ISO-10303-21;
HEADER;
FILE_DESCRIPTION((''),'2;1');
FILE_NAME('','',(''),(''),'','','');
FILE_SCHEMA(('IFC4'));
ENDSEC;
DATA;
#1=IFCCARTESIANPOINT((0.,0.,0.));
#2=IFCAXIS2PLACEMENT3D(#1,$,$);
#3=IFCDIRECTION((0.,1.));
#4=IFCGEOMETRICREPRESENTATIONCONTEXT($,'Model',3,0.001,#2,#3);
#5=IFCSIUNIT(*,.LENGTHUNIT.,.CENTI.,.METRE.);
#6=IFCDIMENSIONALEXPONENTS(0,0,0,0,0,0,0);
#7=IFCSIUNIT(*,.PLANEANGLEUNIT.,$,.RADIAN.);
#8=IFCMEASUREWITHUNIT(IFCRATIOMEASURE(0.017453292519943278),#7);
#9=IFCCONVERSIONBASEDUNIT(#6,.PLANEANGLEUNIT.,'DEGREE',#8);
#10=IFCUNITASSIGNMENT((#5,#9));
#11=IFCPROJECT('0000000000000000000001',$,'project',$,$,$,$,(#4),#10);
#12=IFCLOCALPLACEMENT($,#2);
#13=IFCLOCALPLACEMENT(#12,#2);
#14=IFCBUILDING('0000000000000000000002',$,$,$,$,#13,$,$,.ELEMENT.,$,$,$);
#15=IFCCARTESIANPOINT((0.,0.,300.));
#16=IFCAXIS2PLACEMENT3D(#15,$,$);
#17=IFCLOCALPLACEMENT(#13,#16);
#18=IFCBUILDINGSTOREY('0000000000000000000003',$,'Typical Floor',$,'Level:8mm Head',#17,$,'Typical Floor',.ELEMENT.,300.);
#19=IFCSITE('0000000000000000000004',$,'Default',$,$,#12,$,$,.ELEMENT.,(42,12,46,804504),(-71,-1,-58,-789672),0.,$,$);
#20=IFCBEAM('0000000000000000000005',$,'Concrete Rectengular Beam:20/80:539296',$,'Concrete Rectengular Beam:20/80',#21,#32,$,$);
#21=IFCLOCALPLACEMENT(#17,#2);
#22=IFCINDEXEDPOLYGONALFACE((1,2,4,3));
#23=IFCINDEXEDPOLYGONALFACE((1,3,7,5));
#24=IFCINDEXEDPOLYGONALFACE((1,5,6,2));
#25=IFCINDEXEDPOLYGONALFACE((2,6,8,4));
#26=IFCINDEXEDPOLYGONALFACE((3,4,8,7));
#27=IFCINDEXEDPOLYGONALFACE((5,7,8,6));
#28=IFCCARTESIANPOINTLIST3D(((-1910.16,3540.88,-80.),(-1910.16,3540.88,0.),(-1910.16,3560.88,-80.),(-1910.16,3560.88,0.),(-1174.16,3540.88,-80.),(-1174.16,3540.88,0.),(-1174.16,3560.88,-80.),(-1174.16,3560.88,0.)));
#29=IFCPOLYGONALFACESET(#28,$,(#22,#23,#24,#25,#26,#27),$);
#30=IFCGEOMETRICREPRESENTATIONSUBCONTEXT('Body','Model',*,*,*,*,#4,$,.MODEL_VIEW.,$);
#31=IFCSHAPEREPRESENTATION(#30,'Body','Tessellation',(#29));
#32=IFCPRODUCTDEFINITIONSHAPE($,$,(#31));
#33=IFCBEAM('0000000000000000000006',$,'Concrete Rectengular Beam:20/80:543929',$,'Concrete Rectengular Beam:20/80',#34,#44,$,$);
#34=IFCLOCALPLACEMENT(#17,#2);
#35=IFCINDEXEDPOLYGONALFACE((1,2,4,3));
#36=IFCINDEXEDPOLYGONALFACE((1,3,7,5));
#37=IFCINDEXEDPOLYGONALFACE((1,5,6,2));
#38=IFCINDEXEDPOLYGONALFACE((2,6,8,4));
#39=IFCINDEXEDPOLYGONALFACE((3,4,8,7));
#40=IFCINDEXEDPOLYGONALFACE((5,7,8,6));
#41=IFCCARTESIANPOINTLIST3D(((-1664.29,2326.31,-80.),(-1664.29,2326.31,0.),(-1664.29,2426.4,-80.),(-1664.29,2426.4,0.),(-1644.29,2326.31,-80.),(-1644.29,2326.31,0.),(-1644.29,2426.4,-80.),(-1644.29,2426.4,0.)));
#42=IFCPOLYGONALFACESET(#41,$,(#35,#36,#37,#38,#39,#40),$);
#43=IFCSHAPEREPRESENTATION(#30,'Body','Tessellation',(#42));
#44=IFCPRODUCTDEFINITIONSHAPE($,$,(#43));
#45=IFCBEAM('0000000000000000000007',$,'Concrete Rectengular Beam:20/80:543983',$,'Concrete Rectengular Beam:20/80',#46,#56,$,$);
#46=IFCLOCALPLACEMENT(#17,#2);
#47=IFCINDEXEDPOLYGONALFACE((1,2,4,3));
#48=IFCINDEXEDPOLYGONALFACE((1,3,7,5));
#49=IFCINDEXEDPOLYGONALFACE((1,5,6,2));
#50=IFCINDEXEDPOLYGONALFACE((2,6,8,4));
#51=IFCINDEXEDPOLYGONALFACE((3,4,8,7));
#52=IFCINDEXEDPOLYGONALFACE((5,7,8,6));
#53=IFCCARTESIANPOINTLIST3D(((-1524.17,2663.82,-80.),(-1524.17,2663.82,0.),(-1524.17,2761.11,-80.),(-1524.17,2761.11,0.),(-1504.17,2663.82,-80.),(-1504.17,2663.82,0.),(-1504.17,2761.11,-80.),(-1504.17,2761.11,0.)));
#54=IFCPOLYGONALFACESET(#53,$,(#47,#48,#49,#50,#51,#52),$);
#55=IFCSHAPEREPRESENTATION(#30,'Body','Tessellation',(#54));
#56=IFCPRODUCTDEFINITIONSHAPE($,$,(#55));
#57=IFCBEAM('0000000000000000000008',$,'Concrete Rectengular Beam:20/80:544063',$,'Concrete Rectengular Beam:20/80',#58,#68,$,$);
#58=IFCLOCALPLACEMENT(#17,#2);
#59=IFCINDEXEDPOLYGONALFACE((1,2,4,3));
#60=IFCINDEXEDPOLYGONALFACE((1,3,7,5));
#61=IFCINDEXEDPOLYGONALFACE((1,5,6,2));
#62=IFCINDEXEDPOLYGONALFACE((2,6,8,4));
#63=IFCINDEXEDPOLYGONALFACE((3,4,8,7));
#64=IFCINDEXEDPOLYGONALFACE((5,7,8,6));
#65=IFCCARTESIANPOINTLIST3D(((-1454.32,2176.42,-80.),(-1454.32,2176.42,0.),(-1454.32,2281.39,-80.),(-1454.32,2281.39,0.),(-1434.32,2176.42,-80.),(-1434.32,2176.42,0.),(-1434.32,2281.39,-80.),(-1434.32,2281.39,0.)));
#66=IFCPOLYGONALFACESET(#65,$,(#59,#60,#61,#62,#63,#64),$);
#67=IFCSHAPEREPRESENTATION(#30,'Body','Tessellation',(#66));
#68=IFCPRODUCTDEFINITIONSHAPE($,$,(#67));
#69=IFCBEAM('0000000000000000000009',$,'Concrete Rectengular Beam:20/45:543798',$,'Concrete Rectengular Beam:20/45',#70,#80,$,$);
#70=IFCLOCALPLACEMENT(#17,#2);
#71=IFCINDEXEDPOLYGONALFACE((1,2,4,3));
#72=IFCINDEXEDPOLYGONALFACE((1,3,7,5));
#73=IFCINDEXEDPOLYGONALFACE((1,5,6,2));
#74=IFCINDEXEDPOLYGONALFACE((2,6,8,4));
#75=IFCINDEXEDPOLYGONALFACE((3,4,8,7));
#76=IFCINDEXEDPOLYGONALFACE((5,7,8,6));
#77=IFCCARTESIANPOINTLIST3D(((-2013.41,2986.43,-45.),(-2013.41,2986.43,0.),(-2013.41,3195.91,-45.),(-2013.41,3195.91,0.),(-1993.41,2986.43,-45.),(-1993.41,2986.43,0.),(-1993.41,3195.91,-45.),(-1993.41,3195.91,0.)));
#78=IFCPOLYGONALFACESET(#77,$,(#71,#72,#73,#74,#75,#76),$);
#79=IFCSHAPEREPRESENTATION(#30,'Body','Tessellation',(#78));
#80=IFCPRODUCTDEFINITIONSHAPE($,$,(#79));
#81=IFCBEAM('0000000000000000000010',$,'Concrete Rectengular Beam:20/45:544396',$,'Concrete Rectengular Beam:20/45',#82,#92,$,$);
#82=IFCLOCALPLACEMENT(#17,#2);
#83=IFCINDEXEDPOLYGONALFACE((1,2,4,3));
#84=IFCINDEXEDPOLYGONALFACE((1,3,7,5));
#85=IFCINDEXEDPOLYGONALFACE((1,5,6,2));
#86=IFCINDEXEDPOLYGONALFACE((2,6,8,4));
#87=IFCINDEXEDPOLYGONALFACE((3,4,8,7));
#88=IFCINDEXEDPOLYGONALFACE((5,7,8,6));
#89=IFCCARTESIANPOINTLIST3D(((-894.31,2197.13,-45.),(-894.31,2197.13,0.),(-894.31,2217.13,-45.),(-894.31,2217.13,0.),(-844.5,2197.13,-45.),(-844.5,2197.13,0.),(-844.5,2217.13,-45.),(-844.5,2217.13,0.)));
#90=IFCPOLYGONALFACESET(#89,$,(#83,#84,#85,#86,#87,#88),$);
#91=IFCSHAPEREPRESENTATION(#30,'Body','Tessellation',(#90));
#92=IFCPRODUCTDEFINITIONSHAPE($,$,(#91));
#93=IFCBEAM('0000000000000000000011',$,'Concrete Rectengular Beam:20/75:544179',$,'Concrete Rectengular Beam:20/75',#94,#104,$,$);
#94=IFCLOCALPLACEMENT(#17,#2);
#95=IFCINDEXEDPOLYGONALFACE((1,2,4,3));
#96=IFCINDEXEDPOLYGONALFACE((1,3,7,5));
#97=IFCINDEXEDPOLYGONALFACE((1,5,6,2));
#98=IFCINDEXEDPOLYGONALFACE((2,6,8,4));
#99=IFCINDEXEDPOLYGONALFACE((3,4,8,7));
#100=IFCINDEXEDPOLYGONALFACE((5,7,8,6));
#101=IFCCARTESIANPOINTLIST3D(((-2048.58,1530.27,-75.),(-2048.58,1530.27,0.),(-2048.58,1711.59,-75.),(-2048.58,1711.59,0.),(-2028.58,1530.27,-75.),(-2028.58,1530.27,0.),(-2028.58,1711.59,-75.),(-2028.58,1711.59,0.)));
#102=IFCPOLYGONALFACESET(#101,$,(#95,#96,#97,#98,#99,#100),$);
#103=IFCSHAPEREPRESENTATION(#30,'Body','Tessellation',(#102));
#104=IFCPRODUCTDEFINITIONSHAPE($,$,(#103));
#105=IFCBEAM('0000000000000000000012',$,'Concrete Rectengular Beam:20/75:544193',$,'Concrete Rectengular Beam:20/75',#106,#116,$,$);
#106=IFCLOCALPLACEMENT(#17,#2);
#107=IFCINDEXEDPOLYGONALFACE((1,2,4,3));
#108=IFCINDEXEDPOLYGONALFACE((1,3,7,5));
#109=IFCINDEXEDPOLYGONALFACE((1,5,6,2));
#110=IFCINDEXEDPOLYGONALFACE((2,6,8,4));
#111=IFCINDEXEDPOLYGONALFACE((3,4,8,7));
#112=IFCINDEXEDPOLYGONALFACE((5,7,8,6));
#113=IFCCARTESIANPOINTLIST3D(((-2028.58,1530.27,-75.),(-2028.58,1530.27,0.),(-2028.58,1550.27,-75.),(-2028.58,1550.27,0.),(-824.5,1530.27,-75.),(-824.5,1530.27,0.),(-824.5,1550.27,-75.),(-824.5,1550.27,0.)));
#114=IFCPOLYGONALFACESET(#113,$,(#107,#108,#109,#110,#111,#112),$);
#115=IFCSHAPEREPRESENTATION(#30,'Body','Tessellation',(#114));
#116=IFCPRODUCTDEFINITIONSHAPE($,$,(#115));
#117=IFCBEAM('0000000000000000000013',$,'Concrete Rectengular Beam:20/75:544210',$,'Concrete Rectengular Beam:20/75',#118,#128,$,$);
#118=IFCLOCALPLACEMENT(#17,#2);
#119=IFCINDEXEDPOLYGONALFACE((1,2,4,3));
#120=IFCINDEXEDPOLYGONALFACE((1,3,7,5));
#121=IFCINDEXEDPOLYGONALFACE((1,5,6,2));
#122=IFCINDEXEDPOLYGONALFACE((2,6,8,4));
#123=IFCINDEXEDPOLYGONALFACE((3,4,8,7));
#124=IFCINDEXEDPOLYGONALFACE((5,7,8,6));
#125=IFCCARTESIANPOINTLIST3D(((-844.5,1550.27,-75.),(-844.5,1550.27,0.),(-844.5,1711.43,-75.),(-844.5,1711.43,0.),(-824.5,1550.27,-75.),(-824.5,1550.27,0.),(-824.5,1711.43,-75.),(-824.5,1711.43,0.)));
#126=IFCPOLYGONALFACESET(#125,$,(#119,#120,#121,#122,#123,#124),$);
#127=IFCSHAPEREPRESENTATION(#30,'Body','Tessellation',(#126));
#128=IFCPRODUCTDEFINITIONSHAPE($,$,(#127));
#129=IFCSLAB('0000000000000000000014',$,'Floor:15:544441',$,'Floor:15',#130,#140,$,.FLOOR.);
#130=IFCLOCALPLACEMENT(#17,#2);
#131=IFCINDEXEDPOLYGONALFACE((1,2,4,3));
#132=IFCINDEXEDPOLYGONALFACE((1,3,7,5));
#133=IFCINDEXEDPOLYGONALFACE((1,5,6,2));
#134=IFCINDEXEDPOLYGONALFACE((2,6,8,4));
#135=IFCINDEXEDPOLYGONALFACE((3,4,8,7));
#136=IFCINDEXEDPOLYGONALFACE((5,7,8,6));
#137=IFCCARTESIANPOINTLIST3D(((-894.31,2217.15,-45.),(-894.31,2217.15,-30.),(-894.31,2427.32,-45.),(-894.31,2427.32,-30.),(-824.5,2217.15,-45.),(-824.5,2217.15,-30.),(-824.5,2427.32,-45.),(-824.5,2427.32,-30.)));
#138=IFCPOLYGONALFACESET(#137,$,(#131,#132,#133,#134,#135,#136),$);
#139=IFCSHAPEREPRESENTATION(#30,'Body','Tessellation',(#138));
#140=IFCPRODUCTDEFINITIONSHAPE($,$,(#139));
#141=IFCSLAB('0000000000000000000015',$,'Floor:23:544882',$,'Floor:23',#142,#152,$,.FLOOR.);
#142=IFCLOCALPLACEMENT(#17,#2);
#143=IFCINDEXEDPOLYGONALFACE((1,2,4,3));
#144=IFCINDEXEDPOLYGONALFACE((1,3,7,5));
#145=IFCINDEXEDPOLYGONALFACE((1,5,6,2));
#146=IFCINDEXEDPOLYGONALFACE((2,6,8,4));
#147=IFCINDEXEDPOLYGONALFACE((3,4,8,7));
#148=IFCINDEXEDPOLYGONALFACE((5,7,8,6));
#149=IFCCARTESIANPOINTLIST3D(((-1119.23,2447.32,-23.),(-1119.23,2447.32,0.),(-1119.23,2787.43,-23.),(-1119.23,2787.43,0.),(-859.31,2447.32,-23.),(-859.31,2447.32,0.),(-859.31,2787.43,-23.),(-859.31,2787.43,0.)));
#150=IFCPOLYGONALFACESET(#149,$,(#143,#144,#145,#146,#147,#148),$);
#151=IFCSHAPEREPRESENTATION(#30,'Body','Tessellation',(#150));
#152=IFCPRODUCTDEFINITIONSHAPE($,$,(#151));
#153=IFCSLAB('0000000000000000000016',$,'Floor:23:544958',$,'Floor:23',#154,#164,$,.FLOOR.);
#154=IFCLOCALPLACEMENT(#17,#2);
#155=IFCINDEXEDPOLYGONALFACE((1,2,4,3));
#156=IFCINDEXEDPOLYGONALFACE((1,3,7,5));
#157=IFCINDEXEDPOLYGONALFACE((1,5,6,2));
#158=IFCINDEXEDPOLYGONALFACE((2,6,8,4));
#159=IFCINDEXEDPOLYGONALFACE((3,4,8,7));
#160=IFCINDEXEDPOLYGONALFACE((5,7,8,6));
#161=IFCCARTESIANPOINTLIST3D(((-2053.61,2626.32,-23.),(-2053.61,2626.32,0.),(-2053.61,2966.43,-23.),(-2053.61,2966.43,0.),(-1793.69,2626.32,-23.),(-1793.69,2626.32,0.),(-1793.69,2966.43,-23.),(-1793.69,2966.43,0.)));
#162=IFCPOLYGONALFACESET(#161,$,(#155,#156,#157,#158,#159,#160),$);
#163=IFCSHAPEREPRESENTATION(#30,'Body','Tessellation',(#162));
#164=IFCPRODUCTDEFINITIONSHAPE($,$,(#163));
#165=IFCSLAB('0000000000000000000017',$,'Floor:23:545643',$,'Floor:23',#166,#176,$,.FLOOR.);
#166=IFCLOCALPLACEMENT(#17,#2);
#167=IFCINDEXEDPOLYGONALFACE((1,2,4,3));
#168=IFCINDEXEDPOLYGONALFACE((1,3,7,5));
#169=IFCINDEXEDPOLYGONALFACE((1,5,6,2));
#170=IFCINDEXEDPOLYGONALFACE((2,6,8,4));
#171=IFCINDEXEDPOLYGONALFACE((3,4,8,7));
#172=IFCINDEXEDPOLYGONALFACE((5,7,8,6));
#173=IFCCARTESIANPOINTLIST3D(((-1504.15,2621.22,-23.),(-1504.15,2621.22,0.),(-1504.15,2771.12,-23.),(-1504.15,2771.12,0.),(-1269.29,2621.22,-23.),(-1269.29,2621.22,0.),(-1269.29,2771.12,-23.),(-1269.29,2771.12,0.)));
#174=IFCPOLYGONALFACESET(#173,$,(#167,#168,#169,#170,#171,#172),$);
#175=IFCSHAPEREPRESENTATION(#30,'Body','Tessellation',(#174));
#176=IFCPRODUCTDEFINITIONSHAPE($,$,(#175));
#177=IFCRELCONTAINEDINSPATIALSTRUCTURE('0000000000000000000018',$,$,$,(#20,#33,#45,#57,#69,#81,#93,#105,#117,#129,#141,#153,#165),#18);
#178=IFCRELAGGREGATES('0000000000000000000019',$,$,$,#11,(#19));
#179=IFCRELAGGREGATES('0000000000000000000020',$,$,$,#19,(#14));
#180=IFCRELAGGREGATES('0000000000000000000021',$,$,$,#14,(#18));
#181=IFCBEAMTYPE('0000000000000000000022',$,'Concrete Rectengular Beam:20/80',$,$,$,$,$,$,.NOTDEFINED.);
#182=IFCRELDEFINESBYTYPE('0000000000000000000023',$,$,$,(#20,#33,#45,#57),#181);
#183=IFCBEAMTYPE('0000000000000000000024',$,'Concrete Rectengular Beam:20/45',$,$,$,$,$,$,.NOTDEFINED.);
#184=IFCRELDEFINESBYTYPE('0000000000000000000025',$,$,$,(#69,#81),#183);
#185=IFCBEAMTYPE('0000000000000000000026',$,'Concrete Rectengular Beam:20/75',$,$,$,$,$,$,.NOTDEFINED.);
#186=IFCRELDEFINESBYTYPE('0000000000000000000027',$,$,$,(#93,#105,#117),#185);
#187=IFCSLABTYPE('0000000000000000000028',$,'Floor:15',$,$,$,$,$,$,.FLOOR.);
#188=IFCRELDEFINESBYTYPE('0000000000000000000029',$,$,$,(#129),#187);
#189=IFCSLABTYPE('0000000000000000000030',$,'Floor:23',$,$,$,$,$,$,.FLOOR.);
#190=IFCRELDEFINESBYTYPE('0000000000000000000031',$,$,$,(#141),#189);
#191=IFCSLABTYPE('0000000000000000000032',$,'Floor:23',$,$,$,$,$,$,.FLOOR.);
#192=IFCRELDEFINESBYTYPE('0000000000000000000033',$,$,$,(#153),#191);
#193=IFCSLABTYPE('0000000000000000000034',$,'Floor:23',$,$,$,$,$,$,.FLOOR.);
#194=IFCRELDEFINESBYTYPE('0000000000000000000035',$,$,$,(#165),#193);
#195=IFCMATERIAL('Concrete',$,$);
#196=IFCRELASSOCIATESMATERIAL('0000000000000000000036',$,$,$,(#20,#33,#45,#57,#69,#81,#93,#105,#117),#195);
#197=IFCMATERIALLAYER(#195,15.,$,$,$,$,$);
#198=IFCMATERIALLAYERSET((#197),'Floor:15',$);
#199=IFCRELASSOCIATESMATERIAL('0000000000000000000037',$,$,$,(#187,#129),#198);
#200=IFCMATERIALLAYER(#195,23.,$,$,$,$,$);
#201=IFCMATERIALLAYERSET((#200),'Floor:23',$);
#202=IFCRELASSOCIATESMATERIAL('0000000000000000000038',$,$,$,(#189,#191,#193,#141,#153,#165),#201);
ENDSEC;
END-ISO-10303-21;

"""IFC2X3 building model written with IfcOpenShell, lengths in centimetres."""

from ifc_helpers import new_model, entity, si_unit, converted_unit, direction, frame, frame_2d, origin, place, context, subcontext, project, spatial, rectangle, extrude, material, layer, layer_set, layer_usage, type_object, element, save


model = new_model("IFC2X3")

# Units and contexts
model_context = context("Model", 3, precision=0.001, world=origin(), true_north=direction((0.0, 1.0)))
body_context = subcontext(model_context, "Body", "Model", "MODEL_VIEW")
ifc_project = project(units=[si_unit("LENGTHUNIT", "METRE", prefix="CENTI"), converted_unit("PLANEANGLEUNIT", "DEGREE", entity("IfcRatioMeasure", 0.017453292519943278), si_unit("PLANEANGLEUNIT", "RADIAN"), dimensions=[0, 0, 0, 0, 0, 0, 0])], contexts=[model_context])

# Site, building, storey
site_placement = place(None, origin())
site = spatial("IfcSite", under=ifc_project, at=site_placement, Name="Default", CompositionType="ELEMENT", RefLatitude=(42, 12, 46, 804504), RefLongitude=(-71, -1, -58, -789672), RefElevation=0.0)
building_placement = place(site_placement, origin())
building = spatial("IfcBuilding", under=site, at=building_placement, CompositionType="ELEMENT")
storey_placement = place(building_placement, frame((0.0, 0.0, 300.0)))
storey = spatial("IfcBuildingStorey", under=building, at=storey_placement, Name="Typical Floor", ObjectType="Level:8mm Head", LongName="Typical Floor", CompositionType="ELEMENT", Elevation=300.0)

# Beams
ifc_material = material(Name="Concrete")
beam_type_1 = type_object("IfcBeamType", Name="Concrete Rectengular Beam:20/80", PredefinedType="NOTDEFINED")
beam_1_placement = place(storey_placement, frame((-1950.16, 3550.88, 0.0)))
element("IfcBeam", 1, at=beam_1_placement, inside=storey, type_object=beam_type_1, material=ifc_material, Name="Concrete Rectengular Beam:20/80:539296", ObjectType="Concrete Rectengular Beam:20/80", context=body_context, shape_type="SweptSolid", body=[
    extrude(rectangle(XDim=80.0, YDim=20.0, at=frame_2d((0.0, 0.0), x_axis=(1.0, 0.0))), frame((40.0, 0.0, -40.0), z_axis=(1.0, 0.0, 0.0), x_axis=(0.0, 0.0, -1.0)), (0.0, 0.0, 1.0), 736.0),
])
beam_2_placement = place(storey_placement, frame((-1654.29, 2326.31, 0.0), z_axis=(0.0, 0.0, 1.0), x_axis=(0.0, 1.0, 0.0)))
element("IfcBeam", 2, at=beam_2_placement, inside=storey, type_object=beam_type_1, material=ifc_material, Name="Concrete Rectengular Beam:20/80:543929", ObjectType="Concrete Rectengular Beam:20/80", context=body_context, shape_type="SweptSolid", body=[
    extrude(rectangle(XDim=80.0, YDim=20.0, at=frame_2d((0.0, 0.0), x_axis=(1.0, 0.0))), frame((0.0, 0.0, -40.0), z_axis=(1.0, 0.0, 0.0), x_axis=(0.0, 0.0, -1.0)), (0.0, 0.0, 1.0), 100.09),
])
beam_3_placement = place(storey_placement, frame((-1514.17, 2663.82, 0.0), z_axis=(0.0, 0.0, 1.0), x_axis=(0.0, 1.0, 0.0)))
element("IfcBeam", 3, at=beam_3_placement, inside=storey, type_object=beam_type_1, material=ifc_material, Name="Concrete Rectengular Beam:20/80:543983", ObjectType="Concrete Rectengular Beam:20/80", context=body_context, shape_type="SweptSolid", body=[
    extrude(rectangle(XDim=80.0, YDim=20.0, at=frame_2d((0.0, 0.0), x_axis=(1.0, 0.0))), frame((0.0, 0.0, -40.0), z_axis=(1.0, 0.0, 0.0), x_axis=(0.0, 0.0, -1.0)), (0.0, 0.0, 1.0), 97.3),
])
beam_4_placement = place(storey_placement, frame((-1444.32, 2176.42, 0.0), z_axis=(0.0, 0.0, 1.0), x_axis=(0.0, 1.0, 0.0)))
element("IfcBeam", 4, at=beam_4_placement, inside=storey, type_object=beam_type_1, material=ifc_material, Name="Concrete Rectengular Beam:20/80:544063", ObjectType="Concrete Rectengular Beam:20/80", context=body_context, shape_type="SweptSolid", body=[
    extrude(rectangle(XDim=80.0, YDim=20.0, at=frame_2d((0.0, 0.0), x_axis=(1.0, 0.0))), frame((0.0, 0.0, -40.0), z_axis=(1.0, 0.0, 0.0), x_axis=(0.0, 0.0, -1.0)), (0.0, 0.0, 1.0), 104.98),
])
beam_type_2 = type_object("IfcBeamType", Name="Concrete Rectengular Beam:20/45", PredefinedType="NOTDEFINED")
beam_5_placement = place(storey_placement, frame((-2003.41, 3205.91, 0.0), z_axis=(0.0, 0.0, 1.0), x_axis=(0.0, -1.0, 0.0)))
element("IfcBeam", 5, at=beam_5_placement, inside=storey, type_object=beam_type_2, material=ifc_material, Name="Concrete Rectengular Beam:20/45:543798", ObjectType="Concrete Rectengular Beam:20/45", context=body_context, shape_type="SweptSolid", body=[
    extrude(rectangle(XDim=45.0, YDim=20.0, at=frame_2d((0.0, 0.0), x_axis=(1.0, 0.0))), frame((10.0, 0.0, -22.5), z_axis=(1.0, 0.0, 0.0), x_axis=(0.0, 0.0, -1.0)), (0.0, 0.0, 1.0), 209.49),
])
beam_6_placement = place(storey_placement, frame((-834.5, 2207.13, 0.0), z_axis=(0.0, 0.0, 1.0), x_axis=(-1.0, 0.0, 0.0)))
element("IfcBeam", 6, at=beam_6_placement, inside=storey, type_object=beam_type_2, material=ifc_material, Name="Concrete Rectengular Beam:20/45:544396", ObjectType="Concrete Rectengular Beam:20/45", context=body_context, shape_type="SweptSolid", body=[
    extrude(rectangle(XDim=45.0, YDim=20.0, at=frame_2d((0.0, 0.0), x_axis=(1.0, 0.0))), frame((10.0, 0.0, -22.5), z_axis=(1.0, 0.0, 0.0), x_axis=(0.0, 0.0, -1.0)), (0.0, 0.0, 1.0), 49.81),
])
beam_type_3 = type_object("IfcBeamType", Name="Concrete Rectengular Beam:20/75", PredefinedType="NOTDEFINED")
beam_7_placement = place(storey_placement, frame((-2038.58, 1721.61, 0.0), z_axis=(0.0, 0.0, 1.0), x_axis=(0.0, -1.0, 0.0)))
element("IfcBeam", 7, at=beam_7_placement, inside=storey, type_object=beam_type_3, material=ifc_material, Name="Concrete Rectengular Beam:20/75:544179", ObjectType="Concrete Rectengular Beam:20/75", context=body_context, shape_type="SweptSolid", body=[
    extrude(rectangle(XDim=75.0, YDim=20.0, at=frame_2d((0.0, 0.0), x_axis=(1.0, 0.0))), frame((10.02, 0.0, -37.5), z_axis=(1.0, 0.0, 0.0), x_axis=(0.0, 0.0, -1.0)), (0.0, 0.0, 1.0), 181.32),
])
beam_8_placement = place(storey_placement, frame((-2038.58, 1540.27, 0.0)))
element("IfcBeam", 8, at=beam_8_placement, inside=storey, type_object=beam_type_3, material=ifc_material, Name="Concrete Rectengular Beam:20/75:544193", ObjectType="Concrete Rectengular Beam:20/75", context=body_context, shape_type="SweptSolid", body=[
    extrude(rectangle(XDim=75.0, YDim=20.0, at=frame_2d((0.0, 0.0), x_axis=(1.0, 0.0))), frame((10.0, 0.0, -37.5), z_axis=(1.0, 0.0, 0.0), x_axis=(0.0, 0.0, -1.0)), (0.0, 0.0, 1.0), 1204.07),
])
beam_9_placement = place(storey_placement, frame((-834.5, 1540.27, 0.0), z_axis=(0.0, 0.0, 1.0), x_axis=(0.0, 1.0, 0.0)))
element("IfcBeam", 9, at=beam_9_placement, inside=storey, type_object=beam_type_3, material=ifc_material, Name="Concrete Rectengular Beam:20/75:544210", ObjectType="Concrete Rectengular Beam:20/75", context=body_context, shape_type="SweptSolid", body=[
    extrude(rectangle(XDim=75.0, YDim=20.0, at=frame_2d((0.0, 0.0), x_axis=(1.0, 0.0))), frame((10.0, 0.0, -37.5), z_axis=(1.0, 0.0, 0.0), x_axis=(0.0, 0.0, -1.0)), (0.0, 0.0, 1.0), 161.16),
])

# Slabs
ifc_layer_1 = layer(ifc_material, 15.0)
ifc_layer_set_1 = layer_set([ifc_layer_1], Name="Floor:15")
ifc_layer_usage_1 = layer_usage(ifc_layer_set_1, "AXIS3", "POSITIVE", 0.0)
slab_type_1 = type_object("IfcSlabType", Name="Floor:15", PredefinedType="FLOOR", material=ifc_layer_set_1)
slab_1_placement = place(storey_placement, origin())
element("IfcSlab", 10, at=slab_1_placement, inside=storey, type_object=slab_type_1, material=ifc_layer_usage_1, Name="Floor:15:544441", ObjectType="Floor:15", PredefinedType="FLOOR", context=body_context, shape_type="SweptSolid", body=[
    extrude(rectangle(XDim=210.18, YDim=69.81, at=frame_2d((0.0, 0.0), x_axis=(1.0, 0.0))), frame((-859.41, 2322.23, -30.0), z_axis=(0.0, 0.0, -1.0), x_axis=(0.0, 1.0, 0.0)), (0.0, 0.0, 1.0), 15.0),
])
ifc_layer_2 = layer(ifc_material, 23.0)
ifc_layer_set_2 = layer_set([ifc_layer_2], Name="Floor:23")
ifc_layer_usage_2 = layer_usage(ifc_layer_set_2, "AXIS3", "POSITIVE", 0.0)
slab_type_2 = type_object("IfcSlabType", Name="Floor:23", PredefinedType="FLOOR", material=ifc_layer_set_2)
slab_2_placement = place(storey_placement, origin())
element("IfcSlab", 11, at=slab_2_placement, inside=storey, type_object=slab_type_2, material=ifc_layer_usage_2, Name="Floor:23:544882", ObjectType="Floor:23", PredefinedType="FLOOR", context=body_context, shape_type="SweptSolid", body=[
    extrude(rectangle(XDim=340.1, YDim=259.92, at=frame_2d((0.0, 0.0), x_axis=(1.0, 0.0))), frame((-989.27, 2617.37, 0.0), z_axis=(0.0, 0.0, -1.0), x_axis=(0.0, 1.0, 0.0)), (0.0, 0.0, 1.0), 23.0),
])
ifc_layer_usage_3 = layer_usage(ifc_layer_set_2, "AXIS3", "POSITIVE", 0.0)
slab_type_3 = type_object("IfcSlabType", Name="Floor:23", PredefinedType="FLOOR", material=ifc_layer_set_2)
slab_3_placement = place(storey_placement, origin())
element("IfcSlab", 12, at=slab_3_placement, inside=storey, type_object=slab_type_3, material=ifc_layer_usage_3, Name="Floor:23:544958", ObjectType="Floor:23", PredefinedType="FLOOR", context=body_context, shape_type="SweptSolid", body=[
    extrude(rectangle(XDim=340.1, YDim=259.92, at=frame_2d((0.0, 0.0), x_axis=(1.0, 0.0))), frame((-1923.65, 2796.37, 0.0), z_axis=(0.0, 0.0, -1.0), x_axis=(0.0, 1.0, 0.0)), (0.0, 0.0, 1.0), 23.0),
])
ifc_layer_usage_4 = layer_usage(ifc_layer_set_2, "AXIS3", "POSITIVE", 0.0)
slab_type_4 = type_object("IfcSlabType", Name="Floor:23", PredefinedType="FLOOR", material=ifc_layer_set_2)
slab_4_placement = place(storey_placement, origin())
element("IfcSlab", 13, at=slab_4_placement, inside=storey, type_object=slab_type_4, material=ifc_layer_usage_4, Name="Floor:23:545643", ObjectType="Floor:23", PredefinedType="FLOOR", context=body_context, shape_type="SweptSolid", body=[
    extrude(rectangle(XDim=149.9, YDim=234.86, at=frame_2d((0.0, 0.0), x_axis=(1.0, 0.0))), frame((-1386.72, 2696.17, 0.0), z_axis=(0.0, 0.0, -1.0), x_axis=(0.0, 1.0, 0.0)), (0.0, 0.0, 1.0), 23.0),
])

save(model, "model.ifc")
